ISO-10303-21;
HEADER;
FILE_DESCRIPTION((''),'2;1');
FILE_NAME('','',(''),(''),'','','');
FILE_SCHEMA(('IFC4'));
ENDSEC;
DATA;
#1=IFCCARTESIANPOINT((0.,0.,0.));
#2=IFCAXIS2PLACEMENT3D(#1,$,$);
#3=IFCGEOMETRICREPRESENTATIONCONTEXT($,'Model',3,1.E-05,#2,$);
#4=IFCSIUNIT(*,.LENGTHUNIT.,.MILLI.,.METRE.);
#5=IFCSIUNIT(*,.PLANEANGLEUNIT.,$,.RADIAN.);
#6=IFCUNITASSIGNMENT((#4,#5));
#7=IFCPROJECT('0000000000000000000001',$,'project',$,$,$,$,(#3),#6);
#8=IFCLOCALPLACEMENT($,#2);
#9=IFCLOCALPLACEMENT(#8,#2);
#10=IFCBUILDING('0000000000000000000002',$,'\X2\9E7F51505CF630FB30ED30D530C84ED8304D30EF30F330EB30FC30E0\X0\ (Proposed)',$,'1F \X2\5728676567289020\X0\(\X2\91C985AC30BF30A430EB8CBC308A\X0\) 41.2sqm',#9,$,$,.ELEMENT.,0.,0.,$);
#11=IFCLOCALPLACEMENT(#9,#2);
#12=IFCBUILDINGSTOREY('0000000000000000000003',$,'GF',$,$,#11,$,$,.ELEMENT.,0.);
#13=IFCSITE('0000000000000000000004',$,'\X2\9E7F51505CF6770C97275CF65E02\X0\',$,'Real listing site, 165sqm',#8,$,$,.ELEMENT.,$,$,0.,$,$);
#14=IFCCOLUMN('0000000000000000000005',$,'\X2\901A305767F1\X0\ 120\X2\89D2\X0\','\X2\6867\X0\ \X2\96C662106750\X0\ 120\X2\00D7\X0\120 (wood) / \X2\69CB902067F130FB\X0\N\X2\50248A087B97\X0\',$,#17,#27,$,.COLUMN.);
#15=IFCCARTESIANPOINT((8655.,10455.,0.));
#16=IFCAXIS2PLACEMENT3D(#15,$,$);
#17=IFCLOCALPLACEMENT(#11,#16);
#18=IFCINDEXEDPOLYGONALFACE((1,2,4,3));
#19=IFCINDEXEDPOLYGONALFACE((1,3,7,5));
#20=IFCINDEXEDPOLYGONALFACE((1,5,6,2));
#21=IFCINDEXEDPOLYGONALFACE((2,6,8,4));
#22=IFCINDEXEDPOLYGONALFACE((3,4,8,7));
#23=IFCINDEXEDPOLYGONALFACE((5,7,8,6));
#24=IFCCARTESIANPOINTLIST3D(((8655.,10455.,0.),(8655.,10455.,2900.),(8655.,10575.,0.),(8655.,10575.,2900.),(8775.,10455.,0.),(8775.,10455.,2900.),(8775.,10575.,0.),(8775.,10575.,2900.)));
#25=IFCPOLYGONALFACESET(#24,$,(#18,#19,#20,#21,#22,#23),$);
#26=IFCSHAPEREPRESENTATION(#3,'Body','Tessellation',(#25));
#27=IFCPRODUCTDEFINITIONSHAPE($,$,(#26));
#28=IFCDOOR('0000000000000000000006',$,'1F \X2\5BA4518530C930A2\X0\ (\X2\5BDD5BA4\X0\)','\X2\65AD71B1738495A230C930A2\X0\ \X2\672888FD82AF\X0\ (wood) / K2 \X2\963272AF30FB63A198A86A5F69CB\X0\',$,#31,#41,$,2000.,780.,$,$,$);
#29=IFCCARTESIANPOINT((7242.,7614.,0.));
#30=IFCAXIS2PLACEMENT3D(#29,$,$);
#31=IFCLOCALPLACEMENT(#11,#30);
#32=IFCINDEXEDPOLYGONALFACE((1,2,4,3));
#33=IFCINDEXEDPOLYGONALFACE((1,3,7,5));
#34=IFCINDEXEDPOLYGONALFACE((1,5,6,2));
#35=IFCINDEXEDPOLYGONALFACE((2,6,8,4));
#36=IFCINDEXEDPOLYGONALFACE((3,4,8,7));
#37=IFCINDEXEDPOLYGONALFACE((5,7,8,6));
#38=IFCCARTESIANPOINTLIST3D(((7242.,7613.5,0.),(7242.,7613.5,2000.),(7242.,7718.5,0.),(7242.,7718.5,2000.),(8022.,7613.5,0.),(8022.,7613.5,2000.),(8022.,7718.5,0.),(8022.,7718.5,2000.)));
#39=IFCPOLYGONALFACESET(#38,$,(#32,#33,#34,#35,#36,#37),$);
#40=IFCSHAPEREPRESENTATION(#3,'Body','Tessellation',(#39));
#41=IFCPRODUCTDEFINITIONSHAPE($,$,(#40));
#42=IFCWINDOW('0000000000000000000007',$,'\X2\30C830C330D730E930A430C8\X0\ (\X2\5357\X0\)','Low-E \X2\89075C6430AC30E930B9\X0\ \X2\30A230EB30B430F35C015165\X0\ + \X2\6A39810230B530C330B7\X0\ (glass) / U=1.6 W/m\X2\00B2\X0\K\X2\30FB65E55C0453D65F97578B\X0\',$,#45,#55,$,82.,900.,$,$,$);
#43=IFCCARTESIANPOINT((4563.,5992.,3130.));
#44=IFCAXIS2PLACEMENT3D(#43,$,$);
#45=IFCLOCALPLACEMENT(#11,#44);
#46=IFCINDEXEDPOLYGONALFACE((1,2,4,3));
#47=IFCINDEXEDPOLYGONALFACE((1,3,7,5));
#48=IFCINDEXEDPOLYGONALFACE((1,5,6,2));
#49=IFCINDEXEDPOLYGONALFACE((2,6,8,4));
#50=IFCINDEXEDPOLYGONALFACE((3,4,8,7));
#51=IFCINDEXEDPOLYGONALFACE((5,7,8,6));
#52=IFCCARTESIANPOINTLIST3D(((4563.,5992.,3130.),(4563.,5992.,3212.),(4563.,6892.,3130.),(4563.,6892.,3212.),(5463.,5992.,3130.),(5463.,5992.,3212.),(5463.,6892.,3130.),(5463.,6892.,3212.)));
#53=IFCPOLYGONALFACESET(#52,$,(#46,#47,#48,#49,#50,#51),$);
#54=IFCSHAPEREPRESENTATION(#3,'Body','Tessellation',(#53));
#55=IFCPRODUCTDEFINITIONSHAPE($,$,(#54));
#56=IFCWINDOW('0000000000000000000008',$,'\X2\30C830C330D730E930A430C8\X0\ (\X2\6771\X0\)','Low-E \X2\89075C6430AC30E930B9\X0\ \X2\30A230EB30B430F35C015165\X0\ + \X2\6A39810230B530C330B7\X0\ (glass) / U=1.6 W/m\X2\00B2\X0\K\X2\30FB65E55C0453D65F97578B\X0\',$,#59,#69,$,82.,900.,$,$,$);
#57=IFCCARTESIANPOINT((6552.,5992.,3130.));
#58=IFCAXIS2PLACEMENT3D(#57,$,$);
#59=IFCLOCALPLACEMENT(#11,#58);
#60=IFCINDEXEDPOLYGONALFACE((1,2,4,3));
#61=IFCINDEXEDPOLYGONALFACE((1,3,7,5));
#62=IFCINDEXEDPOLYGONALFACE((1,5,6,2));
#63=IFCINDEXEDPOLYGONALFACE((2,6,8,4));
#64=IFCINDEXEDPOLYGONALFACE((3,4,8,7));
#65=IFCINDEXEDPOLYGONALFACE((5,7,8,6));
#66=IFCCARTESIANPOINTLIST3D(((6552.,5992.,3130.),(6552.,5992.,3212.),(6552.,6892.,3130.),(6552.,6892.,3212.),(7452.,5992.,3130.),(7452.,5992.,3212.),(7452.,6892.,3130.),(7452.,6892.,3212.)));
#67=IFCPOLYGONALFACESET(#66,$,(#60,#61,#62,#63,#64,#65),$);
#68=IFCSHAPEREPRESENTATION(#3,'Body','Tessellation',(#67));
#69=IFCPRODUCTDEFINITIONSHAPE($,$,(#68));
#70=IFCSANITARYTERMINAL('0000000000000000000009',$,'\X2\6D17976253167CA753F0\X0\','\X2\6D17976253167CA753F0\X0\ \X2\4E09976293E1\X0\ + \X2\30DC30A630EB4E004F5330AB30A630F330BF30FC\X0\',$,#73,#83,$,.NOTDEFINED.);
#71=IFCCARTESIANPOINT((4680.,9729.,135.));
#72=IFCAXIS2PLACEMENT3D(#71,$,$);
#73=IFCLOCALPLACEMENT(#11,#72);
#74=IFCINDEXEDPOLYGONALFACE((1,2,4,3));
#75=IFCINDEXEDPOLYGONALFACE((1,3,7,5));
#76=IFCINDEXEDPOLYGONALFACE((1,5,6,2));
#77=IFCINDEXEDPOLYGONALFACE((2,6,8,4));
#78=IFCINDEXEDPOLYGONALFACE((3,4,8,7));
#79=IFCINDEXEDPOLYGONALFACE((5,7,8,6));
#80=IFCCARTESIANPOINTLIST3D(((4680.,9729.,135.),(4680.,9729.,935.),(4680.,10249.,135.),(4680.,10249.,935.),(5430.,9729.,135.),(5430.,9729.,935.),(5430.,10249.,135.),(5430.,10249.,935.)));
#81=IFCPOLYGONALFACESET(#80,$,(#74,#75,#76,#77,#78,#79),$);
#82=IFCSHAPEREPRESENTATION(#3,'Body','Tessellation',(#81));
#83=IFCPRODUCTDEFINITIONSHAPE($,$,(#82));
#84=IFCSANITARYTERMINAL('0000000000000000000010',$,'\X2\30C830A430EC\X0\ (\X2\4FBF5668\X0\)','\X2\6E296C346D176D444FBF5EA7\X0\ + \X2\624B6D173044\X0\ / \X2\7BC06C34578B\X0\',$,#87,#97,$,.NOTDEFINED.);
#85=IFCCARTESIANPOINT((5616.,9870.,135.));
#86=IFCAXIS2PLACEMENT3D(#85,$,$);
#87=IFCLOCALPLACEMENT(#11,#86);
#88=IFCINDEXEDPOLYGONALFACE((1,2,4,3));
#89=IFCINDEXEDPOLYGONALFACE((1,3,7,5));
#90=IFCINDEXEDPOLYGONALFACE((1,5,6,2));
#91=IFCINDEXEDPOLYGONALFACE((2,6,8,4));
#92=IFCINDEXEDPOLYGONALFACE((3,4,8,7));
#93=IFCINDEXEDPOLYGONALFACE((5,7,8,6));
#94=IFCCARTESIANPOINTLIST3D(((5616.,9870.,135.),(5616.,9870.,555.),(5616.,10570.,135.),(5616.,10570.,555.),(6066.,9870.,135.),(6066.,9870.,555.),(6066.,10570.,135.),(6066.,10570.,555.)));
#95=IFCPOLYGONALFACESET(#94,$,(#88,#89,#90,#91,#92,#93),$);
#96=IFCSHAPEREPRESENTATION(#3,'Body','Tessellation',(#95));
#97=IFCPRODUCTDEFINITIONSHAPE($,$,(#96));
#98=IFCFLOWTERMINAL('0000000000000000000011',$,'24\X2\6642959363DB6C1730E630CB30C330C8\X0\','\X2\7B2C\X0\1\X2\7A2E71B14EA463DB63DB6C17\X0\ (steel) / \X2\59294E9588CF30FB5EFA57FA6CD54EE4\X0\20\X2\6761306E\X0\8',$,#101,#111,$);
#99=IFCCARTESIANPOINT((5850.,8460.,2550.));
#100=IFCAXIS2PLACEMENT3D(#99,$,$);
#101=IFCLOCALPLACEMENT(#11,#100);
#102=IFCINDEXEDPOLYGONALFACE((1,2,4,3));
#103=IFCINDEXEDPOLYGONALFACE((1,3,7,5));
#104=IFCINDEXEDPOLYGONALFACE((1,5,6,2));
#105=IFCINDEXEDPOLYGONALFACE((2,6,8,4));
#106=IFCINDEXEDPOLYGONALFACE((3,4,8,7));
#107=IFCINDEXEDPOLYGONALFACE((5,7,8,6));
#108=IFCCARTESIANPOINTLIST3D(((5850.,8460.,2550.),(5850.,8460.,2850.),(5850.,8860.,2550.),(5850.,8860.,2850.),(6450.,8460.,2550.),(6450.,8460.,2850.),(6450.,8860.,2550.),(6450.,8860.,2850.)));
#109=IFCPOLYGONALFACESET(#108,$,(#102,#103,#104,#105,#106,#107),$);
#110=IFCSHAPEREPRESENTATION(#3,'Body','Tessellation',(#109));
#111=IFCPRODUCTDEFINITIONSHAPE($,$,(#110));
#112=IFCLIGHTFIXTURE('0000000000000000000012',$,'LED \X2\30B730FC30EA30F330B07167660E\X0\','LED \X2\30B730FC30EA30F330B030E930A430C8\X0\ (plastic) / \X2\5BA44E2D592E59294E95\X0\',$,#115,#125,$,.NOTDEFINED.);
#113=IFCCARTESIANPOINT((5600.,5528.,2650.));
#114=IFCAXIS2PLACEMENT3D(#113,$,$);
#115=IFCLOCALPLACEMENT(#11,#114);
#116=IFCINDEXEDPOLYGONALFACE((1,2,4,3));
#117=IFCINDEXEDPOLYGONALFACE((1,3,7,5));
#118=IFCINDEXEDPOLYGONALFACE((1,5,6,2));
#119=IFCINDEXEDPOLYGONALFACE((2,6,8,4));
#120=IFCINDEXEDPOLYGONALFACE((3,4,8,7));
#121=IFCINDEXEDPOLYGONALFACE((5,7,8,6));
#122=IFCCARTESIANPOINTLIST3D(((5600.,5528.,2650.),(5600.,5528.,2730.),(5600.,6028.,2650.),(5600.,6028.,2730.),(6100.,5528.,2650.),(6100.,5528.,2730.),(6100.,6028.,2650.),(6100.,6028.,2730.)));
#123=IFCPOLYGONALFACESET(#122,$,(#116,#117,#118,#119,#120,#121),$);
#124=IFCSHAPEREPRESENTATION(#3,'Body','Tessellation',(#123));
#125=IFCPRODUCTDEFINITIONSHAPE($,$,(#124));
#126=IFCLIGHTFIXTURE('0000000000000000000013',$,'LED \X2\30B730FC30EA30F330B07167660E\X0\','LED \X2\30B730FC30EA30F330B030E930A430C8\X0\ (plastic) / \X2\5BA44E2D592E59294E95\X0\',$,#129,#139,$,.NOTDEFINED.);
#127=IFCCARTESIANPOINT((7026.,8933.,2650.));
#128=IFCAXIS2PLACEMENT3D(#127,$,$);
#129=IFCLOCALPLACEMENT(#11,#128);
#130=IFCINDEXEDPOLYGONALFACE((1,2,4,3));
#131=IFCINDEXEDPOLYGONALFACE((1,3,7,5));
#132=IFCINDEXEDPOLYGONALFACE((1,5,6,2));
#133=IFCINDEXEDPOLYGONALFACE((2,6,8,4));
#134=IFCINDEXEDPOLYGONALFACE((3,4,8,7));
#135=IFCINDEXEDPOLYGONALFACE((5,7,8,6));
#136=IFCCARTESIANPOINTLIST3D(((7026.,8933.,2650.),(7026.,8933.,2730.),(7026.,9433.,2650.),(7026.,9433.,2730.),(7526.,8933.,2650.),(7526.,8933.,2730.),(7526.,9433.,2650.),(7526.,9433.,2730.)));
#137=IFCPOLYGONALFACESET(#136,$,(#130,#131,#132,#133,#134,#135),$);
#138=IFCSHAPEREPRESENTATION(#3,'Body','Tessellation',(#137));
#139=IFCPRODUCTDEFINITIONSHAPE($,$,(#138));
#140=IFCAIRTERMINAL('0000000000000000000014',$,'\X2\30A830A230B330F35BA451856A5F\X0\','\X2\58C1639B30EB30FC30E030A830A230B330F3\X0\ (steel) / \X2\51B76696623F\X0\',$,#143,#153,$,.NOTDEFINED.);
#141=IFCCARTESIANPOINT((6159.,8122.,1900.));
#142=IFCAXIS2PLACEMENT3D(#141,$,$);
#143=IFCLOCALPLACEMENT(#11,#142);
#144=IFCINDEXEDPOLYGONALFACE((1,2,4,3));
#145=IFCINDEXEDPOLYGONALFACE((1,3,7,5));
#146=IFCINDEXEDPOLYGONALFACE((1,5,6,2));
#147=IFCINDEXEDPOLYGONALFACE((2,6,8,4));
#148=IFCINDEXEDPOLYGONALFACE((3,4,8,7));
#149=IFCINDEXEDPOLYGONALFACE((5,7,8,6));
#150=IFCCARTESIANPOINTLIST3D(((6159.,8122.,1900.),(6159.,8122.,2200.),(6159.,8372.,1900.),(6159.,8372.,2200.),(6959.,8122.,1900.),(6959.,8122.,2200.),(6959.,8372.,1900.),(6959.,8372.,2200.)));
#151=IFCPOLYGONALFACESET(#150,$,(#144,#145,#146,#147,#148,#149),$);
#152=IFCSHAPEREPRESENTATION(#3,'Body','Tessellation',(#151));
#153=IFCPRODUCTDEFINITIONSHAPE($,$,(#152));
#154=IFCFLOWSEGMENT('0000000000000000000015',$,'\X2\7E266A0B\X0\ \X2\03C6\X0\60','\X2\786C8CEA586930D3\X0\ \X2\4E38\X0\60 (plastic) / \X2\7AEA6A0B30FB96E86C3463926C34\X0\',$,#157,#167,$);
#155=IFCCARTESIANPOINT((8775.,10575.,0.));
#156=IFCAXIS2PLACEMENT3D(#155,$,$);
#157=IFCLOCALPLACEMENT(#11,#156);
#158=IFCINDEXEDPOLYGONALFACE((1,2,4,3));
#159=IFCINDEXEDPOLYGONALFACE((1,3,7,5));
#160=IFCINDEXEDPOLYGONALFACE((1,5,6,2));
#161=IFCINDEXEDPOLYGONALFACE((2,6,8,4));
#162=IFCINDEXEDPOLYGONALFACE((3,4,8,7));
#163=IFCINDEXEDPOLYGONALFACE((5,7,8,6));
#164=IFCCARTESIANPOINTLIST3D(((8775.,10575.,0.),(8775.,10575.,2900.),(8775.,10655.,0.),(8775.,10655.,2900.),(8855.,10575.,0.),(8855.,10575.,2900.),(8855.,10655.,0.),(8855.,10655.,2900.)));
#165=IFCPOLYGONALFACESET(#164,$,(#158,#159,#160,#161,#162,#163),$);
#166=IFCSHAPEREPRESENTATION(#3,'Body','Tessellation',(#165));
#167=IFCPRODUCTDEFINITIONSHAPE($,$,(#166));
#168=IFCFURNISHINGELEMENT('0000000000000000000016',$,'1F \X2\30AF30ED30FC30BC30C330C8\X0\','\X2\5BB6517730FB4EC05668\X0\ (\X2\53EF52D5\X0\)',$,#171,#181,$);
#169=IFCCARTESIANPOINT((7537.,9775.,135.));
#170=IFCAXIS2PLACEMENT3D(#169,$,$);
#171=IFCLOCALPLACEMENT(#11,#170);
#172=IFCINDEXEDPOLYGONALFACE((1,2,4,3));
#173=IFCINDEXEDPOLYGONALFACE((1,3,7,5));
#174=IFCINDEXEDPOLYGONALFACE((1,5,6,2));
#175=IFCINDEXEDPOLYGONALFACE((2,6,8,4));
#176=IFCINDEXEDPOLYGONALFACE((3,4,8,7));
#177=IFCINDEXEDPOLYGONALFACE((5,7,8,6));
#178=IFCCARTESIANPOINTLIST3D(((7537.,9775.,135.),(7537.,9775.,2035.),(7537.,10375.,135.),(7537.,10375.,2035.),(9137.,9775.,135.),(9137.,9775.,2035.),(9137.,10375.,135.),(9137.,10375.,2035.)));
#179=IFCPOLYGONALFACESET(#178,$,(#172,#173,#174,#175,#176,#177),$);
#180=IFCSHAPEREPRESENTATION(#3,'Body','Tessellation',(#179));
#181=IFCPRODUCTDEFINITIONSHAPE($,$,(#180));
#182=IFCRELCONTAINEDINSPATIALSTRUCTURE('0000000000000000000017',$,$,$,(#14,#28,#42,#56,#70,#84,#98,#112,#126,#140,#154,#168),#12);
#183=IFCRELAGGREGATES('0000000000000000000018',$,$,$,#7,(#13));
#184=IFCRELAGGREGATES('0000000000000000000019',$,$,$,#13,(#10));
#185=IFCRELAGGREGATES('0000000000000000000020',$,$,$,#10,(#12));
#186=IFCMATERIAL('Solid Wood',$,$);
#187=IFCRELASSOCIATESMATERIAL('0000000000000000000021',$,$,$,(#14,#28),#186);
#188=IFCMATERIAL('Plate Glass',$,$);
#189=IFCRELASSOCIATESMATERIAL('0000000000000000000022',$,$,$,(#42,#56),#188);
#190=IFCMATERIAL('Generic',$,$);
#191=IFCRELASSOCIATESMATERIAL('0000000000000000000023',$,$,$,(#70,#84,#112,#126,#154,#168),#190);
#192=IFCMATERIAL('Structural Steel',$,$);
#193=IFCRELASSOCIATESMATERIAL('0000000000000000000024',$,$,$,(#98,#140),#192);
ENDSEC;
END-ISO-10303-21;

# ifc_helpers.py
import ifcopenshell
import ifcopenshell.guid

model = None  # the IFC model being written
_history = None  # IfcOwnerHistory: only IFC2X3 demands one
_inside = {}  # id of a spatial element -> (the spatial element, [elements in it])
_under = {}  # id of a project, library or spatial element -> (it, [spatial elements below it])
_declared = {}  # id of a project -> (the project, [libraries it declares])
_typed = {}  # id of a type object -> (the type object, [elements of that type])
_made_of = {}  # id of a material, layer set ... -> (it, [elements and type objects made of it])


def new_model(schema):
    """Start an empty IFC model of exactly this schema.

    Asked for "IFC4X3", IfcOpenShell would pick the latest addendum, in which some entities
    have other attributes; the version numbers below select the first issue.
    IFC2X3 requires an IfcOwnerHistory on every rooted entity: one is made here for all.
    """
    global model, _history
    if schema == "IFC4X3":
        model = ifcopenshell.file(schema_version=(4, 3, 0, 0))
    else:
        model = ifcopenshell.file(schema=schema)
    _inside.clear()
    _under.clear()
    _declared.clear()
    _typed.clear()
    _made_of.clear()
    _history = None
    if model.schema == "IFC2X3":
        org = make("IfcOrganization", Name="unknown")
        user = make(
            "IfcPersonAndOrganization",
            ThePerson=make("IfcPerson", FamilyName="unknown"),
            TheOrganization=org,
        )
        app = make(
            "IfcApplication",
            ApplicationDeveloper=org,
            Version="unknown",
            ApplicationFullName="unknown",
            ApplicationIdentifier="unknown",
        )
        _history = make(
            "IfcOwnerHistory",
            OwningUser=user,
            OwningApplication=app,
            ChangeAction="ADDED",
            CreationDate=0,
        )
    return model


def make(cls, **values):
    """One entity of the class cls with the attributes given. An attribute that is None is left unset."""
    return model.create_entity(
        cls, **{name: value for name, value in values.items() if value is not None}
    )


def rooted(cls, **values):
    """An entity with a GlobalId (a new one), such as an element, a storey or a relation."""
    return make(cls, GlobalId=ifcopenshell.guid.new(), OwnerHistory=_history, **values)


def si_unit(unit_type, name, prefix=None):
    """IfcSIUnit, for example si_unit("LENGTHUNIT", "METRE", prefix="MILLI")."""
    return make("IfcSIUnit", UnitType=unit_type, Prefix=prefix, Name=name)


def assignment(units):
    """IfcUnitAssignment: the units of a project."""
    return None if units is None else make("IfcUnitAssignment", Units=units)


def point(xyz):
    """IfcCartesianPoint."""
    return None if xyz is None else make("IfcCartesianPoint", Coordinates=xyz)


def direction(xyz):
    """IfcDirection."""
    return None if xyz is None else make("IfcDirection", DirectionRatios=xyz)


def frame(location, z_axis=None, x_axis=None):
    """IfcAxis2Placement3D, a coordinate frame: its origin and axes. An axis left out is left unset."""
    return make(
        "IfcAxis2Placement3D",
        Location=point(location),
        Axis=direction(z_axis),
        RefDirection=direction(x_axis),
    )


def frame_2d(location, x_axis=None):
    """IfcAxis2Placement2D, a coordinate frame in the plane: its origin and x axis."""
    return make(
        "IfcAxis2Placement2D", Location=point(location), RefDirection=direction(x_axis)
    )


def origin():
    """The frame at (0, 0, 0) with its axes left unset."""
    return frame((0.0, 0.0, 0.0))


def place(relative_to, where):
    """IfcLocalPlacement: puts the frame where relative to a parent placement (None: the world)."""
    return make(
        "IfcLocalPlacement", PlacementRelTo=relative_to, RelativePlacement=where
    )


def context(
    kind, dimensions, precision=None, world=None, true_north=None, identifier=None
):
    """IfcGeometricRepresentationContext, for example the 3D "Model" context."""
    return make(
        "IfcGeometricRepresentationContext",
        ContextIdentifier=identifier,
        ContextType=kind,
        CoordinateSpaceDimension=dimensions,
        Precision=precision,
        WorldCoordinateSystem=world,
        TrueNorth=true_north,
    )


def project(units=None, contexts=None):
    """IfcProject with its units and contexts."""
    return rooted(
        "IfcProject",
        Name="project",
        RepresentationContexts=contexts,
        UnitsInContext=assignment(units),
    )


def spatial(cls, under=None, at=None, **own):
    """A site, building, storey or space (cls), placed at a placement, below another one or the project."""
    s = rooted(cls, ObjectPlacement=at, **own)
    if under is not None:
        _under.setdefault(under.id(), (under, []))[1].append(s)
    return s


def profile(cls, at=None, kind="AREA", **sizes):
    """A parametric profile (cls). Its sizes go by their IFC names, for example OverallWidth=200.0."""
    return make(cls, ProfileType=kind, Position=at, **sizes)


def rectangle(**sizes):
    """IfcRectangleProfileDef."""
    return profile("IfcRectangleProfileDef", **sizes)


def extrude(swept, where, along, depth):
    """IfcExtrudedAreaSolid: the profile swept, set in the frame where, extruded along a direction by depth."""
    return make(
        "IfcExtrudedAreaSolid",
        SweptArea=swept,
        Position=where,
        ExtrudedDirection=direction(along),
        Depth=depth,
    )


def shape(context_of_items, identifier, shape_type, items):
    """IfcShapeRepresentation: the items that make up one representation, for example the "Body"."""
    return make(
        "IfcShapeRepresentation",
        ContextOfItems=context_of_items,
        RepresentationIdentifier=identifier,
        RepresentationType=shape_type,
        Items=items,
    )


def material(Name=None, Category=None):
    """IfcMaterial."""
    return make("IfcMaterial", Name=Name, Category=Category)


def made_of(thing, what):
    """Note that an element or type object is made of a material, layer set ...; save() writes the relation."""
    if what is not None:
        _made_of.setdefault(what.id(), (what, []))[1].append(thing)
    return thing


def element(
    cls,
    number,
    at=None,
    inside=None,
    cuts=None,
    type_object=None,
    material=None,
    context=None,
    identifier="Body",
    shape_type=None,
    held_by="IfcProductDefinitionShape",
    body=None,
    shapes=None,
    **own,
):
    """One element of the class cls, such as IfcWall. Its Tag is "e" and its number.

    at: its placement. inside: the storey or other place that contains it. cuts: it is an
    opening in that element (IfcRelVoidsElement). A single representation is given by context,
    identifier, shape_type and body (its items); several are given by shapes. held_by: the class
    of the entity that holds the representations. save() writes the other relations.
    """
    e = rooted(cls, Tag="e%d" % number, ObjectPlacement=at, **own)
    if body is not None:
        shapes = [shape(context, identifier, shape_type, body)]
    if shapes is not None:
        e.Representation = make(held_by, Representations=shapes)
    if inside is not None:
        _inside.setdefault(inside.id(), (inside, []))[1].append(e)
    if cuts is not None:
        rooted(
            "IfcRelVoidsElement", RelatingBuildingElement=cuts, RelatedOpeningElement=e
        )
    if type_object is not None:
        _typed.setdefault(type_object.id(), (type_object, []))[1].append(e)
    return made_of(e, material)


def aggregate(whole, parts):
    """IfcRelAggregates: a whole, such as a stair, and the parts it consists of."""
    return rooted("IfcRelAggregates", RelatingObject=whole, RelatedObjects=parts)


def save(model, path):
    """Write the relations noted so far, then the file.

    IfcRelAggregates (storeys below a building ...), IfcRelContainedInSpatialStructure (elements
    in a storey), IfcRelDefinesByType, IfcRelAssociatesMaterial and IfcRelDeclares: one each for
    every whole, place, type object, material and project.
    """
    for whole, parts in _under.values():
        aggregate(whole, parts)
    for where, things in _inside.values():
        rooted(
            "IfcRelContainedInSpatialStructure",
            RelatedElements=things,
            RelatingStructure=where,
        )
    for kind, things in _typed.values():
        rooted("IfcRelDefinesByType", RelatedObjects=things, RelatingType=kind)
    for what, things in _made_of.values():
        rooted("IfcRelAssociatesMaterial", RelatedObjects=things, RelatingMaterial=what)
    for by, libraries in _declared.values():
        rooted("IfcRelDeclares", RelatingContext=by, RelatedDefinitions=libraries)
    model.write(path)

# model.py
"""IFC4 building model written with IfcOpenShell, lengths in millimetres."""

from ifc_helpers import new_model, si_unit, frame, frame_2d, origin, place, context, project, spatial, rectangle, extrude, material, element, save


model = new_model("IFC4")

# Units and contexts
model_context = context("Model", 3, precision=1e-05, world=origin())
ifc_project = project(units=[si_unit("LENGTHUNIT", "METRE", prefix="MILLI"), si_unit("PLANEANGLEUNIT", "RADIAN")], contexts=[model_context])

# Site, building, storey
site_placement = place(None, origin())
site = spatial("IfcSite", under=ifc_project, at=site_placement, Name="鹿児島県霧島市", ObjectType="Real listing site, 165sqm", CompositionType="ELEMENT", RefElevation=0.0)
building_placement = place(site_placement, origin())
building = spatial("IfcBuilding", under=site, at=building_placement, Name="鹿児島・ロフト付きワンルーム (Proposed)", ObjectType="1F 在来木造(釉薬タイル貼り) 41.2sqm", CompositionType="ELEMENT", ElevationOfRefHeight=0.0, ElevationOfTerrain=0.0)
storey_placement = place(building_placement, origin())
storey = spatial("IfcBuildingStorey", under=building, at=storey_placement, Name="GF", CompositionType="ELEMENT", Elevation=0.0)

# Column
ifc_material_1 = material(Name="Solid Wood")
column_1_placement = place(storey_placement, frame((8655.0, 10455.0, 0.0)))
element("IfcColumn", 1, at=column_1_placement, inside=storey, material=ifc_material_1, Name="通し柱 120角", Description="桧 集成材 120×120 (wood) / 構造柱・N値計算", PredefinedType="COLUMN", context=model_context, shape_type="SweptSolid", body=[
    extrude(rectangle(XDim=120.0, YDim=120.0, at=frame_2d((60.0, 60.0))), frame((8655.0, 10455.0, 0.0)), (0.0, 0.0, 1.0), 2900.0),
])

# Door
door_placement = place(storey_placement, frame((7242.0, 7614.0, 0.0)))
element("IfcDoor", 2, at=door_placement, inside=storey, material=ifc_material_1, Name="1F 室内ドア (寝室)", Description="断熱玄関ドア 木製芯 (wood) / K2 防犯・採風機構", OverallHeight=2000.0, OverallWidth=780.0, context=model_context, shape_type="SweptSolid", body=[
    extrude(rectangle(XDim=780.0, YDim=105.0, at=frame_2d((390.0, 52.0))), frame((7242.0, 7614.0, 0.0)), (0.0, 0.0, 1.0), 2000.0),
])

# Windows
ifc_material_2 = material(Name="Plate Glass")
window_1_placement = place(storey_placement, frame((4563.0, 5992.0, 3130.0)))
element("IfcWindow", 3, at=window_1_placement, inside=storey, material=ifc_material_2, Name="トップライト (南)", Description="Low-E 複層ガラス アルゴン封入 + 樹脂サッシ (glass) / U=1.6 W/m²K・日射取得型", OverallHeight=82.0, OverallWidth=900.0, context=model_context, shape_type="SweptSolid", body=[
    extrude(rectangle(XDim=900.0, YDim=900.0, at=frame_2d((450.0, 450.0))), frame((4563.0, 5992.0, 3130.0)), (0.0, 0.0, 1.0), 82.0),
])
window_2_placement = place(storey_placement, frame((6552.0, 5992.0, 3130.0)))
element("IfcWindow", 4, at=window_2_placement, inside=storey, material=ifc_material_2, Name="トップライト (東)", Description="Low-E 複層ガラス アルゴン封入 + 樹脂サッシ (glass) / U=1.6 W/m²K・日射取得型", OverallHeight=82.0, OverallWidth=900.0, context=model_context, shape_type="SweptSolid", body=[
    extrude(rectangle(XDim=900.0, YDim=900.0, at=frame_2d((450.0, 450.0))), frame((6552.0, 5992.0, 3130.0)), (0.0, 0.0, 1.0), 82.0),
])

# Sanitary terminals
ifc_material_3 = material(Name="Generic")
sanitary_terminal_1_placement = place(storey_placement, frame((4680.0, 9729.0, 135.0)))
element("IfcSanitaryTerminal", 5, at=sanitary_terminal_1_placement, inside=storey, material=ifc_material_3, Name="洗面化粧台", Description="洗面化粧台 三面鏡 + ボウル一体カウンター", PredefinedType="NOTDEFINED", context=model_context, shape_type="SweptSolid", body=[
    extrude(rectangle(XDim=750.0, YDim=520.0, at=frame_2d((375.0, 260.0))), frame((4680.0, 9729.0, 135.0)), (0.0, 0.0, 1.0), 800.0),
])
sanitary_terminal_2_placement = place(storey_placement, frame((5616.0, 9870.0, 135.0)))
element("IfcSanitaryTerminal", 6, at=sanitary_terminal_2_placement, inside=storey, material=ifc_material_3, Name="トイレ (便器)", Description="温水洗浄便座 + 手洗い / 節水型", PredefinedType="NOTDEFINED", context=model_context, shape_type="SweptSolid", body=[
    extrude(rectangle(XDim=450.0, YDim=700.0, at=frame_2d((225.0, 350.0))), frame((5616.0, 9870.0, 135.0)), (0.0, 0.0, 1.0), 420.0),
])

# Flow terminal
ifc_material_4 = material(Name="Structural Steel")
flow_terminal_placement = place(storey_placement, frame((5850.0, 8460.0, 2550.0)))
element("IfcFlowTerminal", 7, at=flow_terminal_placement, inside=storey, material=ifc_material_4, Name="24時間換気ユニット", Description="第1種熱交換換気 (steel) / 天井裏・建基法令20条の8", context=model_context, shape_type="SweptSolid", body=[
    extrude(rectangle(XDim=600.0, YDim=400.0, at=frame_2d((300.0, 200.0))), frame((5850.0, 8460.0, 2550.0)), (0.0, 0.0, 1.0), 300.0),
])

# Light fixtures
light_fixture_1_placement = place(storey_placement, frame((5600.0, 5528.0, 2650.0)))
element("IfcLightFixture", 8, at=light_fixture_1_placement, inside=storey, material=ifc_material_3, Name="LED シーリング照明", Description="LED シーリングライト (plastic) / 室中央天井", PredefinedType="NOTDEFINED", context=model_context, shape_type="SweptSolid", body=[
    extrude(rectangle(XDim=500.0, YDim=500.0, at=frame_2d((250.0, 250.0))), frame((5600.0, 5528.0, 2650.0)), (0.0, 0.0, 1.0), 80.0),
])
light_fixture_2_placement = place(storey_placement, frame((7026.0, 8933.0, 2650.0)))
element("IfcLightFixture", 9, at=light_fixture_2_placement, inside=storey, material=ifc_material_3, Name="LED シーリング照明", Description="LED シーリングライト (plastic) / 室中央天井", PredefinedType="NOTDEFINED", context=model_context, shape_type="SweptSolid", body=[
    extrude(rectangle(XDim=500.0, YDim=500.0, at=frame_2d((250.0, 250.0))), frame((7026.0, 8933.0, 2650.0)), (0.0, 0.0, 1.0), 80.0),
])

# Air terminal
air_terminal_placement = place(storey_placement, frame((6159.0, 8122.0, 1900.0)))
element("IfcAirTerminal", 10, at=air_terminal_placement, inside=storey, material=ifc_material_4, Name="エアコン室内機", Description="壁掛ルームエアコン (steel) / 冷暖房", PredefinedType="NOTDEFINED", context=model_context, shape_type="SweptSolid", body=[
    extrude(rectangle(XDim=800.0, YDim=250.0, at=frame_2d((400.0, 125.0))), frame((6159.0, 8122.0, 1900.0)), (0.0, 0.0, 1.0), 300.0),
])

# Flow segment
flow_segment_placement = place(storey_placement, frame((8775.0, 10575.0, 0.0)))
element("IfcFlowSegment", 11, at=flow_segment_placement, inside=storey, material=ifc_material_3, Name="縦樋 φ60", Description="硬質塩ビ 丸60 (plastic) / 竪樋・雨水排水", context=model_context, shape_type="SweptSolid", body=[
    extrude(rectangle(XDim=80.0, YDim=80.0, at=frame_2d((40.0, 40.0))), frame((8775.0, 10575.0, 0.0)), (0.0, 0.0, 1.0), 2900.0),
])

# Furnishing element
furnishing_placement = place(storey_placement, frame((7537.0, 9775.0, 135.0)))
element("IfcFurnishingElement", 12, at=furnishing_placement, inside=storey, material=ifc_material_3, Name="1F クローゼット", Description="家具・什器 (可動)", context=model_context, shape_type="SweptSolid", body=[
    extrude(rectangle(XDim=1600.0, YDim=600.0, at=frame_2d((800.0, 300.0))), frame((7537.0, 9775.0, 135.0)), (0.0, 0.0, 1.0), 1900.0),
])

save(model, "model.ifc")
